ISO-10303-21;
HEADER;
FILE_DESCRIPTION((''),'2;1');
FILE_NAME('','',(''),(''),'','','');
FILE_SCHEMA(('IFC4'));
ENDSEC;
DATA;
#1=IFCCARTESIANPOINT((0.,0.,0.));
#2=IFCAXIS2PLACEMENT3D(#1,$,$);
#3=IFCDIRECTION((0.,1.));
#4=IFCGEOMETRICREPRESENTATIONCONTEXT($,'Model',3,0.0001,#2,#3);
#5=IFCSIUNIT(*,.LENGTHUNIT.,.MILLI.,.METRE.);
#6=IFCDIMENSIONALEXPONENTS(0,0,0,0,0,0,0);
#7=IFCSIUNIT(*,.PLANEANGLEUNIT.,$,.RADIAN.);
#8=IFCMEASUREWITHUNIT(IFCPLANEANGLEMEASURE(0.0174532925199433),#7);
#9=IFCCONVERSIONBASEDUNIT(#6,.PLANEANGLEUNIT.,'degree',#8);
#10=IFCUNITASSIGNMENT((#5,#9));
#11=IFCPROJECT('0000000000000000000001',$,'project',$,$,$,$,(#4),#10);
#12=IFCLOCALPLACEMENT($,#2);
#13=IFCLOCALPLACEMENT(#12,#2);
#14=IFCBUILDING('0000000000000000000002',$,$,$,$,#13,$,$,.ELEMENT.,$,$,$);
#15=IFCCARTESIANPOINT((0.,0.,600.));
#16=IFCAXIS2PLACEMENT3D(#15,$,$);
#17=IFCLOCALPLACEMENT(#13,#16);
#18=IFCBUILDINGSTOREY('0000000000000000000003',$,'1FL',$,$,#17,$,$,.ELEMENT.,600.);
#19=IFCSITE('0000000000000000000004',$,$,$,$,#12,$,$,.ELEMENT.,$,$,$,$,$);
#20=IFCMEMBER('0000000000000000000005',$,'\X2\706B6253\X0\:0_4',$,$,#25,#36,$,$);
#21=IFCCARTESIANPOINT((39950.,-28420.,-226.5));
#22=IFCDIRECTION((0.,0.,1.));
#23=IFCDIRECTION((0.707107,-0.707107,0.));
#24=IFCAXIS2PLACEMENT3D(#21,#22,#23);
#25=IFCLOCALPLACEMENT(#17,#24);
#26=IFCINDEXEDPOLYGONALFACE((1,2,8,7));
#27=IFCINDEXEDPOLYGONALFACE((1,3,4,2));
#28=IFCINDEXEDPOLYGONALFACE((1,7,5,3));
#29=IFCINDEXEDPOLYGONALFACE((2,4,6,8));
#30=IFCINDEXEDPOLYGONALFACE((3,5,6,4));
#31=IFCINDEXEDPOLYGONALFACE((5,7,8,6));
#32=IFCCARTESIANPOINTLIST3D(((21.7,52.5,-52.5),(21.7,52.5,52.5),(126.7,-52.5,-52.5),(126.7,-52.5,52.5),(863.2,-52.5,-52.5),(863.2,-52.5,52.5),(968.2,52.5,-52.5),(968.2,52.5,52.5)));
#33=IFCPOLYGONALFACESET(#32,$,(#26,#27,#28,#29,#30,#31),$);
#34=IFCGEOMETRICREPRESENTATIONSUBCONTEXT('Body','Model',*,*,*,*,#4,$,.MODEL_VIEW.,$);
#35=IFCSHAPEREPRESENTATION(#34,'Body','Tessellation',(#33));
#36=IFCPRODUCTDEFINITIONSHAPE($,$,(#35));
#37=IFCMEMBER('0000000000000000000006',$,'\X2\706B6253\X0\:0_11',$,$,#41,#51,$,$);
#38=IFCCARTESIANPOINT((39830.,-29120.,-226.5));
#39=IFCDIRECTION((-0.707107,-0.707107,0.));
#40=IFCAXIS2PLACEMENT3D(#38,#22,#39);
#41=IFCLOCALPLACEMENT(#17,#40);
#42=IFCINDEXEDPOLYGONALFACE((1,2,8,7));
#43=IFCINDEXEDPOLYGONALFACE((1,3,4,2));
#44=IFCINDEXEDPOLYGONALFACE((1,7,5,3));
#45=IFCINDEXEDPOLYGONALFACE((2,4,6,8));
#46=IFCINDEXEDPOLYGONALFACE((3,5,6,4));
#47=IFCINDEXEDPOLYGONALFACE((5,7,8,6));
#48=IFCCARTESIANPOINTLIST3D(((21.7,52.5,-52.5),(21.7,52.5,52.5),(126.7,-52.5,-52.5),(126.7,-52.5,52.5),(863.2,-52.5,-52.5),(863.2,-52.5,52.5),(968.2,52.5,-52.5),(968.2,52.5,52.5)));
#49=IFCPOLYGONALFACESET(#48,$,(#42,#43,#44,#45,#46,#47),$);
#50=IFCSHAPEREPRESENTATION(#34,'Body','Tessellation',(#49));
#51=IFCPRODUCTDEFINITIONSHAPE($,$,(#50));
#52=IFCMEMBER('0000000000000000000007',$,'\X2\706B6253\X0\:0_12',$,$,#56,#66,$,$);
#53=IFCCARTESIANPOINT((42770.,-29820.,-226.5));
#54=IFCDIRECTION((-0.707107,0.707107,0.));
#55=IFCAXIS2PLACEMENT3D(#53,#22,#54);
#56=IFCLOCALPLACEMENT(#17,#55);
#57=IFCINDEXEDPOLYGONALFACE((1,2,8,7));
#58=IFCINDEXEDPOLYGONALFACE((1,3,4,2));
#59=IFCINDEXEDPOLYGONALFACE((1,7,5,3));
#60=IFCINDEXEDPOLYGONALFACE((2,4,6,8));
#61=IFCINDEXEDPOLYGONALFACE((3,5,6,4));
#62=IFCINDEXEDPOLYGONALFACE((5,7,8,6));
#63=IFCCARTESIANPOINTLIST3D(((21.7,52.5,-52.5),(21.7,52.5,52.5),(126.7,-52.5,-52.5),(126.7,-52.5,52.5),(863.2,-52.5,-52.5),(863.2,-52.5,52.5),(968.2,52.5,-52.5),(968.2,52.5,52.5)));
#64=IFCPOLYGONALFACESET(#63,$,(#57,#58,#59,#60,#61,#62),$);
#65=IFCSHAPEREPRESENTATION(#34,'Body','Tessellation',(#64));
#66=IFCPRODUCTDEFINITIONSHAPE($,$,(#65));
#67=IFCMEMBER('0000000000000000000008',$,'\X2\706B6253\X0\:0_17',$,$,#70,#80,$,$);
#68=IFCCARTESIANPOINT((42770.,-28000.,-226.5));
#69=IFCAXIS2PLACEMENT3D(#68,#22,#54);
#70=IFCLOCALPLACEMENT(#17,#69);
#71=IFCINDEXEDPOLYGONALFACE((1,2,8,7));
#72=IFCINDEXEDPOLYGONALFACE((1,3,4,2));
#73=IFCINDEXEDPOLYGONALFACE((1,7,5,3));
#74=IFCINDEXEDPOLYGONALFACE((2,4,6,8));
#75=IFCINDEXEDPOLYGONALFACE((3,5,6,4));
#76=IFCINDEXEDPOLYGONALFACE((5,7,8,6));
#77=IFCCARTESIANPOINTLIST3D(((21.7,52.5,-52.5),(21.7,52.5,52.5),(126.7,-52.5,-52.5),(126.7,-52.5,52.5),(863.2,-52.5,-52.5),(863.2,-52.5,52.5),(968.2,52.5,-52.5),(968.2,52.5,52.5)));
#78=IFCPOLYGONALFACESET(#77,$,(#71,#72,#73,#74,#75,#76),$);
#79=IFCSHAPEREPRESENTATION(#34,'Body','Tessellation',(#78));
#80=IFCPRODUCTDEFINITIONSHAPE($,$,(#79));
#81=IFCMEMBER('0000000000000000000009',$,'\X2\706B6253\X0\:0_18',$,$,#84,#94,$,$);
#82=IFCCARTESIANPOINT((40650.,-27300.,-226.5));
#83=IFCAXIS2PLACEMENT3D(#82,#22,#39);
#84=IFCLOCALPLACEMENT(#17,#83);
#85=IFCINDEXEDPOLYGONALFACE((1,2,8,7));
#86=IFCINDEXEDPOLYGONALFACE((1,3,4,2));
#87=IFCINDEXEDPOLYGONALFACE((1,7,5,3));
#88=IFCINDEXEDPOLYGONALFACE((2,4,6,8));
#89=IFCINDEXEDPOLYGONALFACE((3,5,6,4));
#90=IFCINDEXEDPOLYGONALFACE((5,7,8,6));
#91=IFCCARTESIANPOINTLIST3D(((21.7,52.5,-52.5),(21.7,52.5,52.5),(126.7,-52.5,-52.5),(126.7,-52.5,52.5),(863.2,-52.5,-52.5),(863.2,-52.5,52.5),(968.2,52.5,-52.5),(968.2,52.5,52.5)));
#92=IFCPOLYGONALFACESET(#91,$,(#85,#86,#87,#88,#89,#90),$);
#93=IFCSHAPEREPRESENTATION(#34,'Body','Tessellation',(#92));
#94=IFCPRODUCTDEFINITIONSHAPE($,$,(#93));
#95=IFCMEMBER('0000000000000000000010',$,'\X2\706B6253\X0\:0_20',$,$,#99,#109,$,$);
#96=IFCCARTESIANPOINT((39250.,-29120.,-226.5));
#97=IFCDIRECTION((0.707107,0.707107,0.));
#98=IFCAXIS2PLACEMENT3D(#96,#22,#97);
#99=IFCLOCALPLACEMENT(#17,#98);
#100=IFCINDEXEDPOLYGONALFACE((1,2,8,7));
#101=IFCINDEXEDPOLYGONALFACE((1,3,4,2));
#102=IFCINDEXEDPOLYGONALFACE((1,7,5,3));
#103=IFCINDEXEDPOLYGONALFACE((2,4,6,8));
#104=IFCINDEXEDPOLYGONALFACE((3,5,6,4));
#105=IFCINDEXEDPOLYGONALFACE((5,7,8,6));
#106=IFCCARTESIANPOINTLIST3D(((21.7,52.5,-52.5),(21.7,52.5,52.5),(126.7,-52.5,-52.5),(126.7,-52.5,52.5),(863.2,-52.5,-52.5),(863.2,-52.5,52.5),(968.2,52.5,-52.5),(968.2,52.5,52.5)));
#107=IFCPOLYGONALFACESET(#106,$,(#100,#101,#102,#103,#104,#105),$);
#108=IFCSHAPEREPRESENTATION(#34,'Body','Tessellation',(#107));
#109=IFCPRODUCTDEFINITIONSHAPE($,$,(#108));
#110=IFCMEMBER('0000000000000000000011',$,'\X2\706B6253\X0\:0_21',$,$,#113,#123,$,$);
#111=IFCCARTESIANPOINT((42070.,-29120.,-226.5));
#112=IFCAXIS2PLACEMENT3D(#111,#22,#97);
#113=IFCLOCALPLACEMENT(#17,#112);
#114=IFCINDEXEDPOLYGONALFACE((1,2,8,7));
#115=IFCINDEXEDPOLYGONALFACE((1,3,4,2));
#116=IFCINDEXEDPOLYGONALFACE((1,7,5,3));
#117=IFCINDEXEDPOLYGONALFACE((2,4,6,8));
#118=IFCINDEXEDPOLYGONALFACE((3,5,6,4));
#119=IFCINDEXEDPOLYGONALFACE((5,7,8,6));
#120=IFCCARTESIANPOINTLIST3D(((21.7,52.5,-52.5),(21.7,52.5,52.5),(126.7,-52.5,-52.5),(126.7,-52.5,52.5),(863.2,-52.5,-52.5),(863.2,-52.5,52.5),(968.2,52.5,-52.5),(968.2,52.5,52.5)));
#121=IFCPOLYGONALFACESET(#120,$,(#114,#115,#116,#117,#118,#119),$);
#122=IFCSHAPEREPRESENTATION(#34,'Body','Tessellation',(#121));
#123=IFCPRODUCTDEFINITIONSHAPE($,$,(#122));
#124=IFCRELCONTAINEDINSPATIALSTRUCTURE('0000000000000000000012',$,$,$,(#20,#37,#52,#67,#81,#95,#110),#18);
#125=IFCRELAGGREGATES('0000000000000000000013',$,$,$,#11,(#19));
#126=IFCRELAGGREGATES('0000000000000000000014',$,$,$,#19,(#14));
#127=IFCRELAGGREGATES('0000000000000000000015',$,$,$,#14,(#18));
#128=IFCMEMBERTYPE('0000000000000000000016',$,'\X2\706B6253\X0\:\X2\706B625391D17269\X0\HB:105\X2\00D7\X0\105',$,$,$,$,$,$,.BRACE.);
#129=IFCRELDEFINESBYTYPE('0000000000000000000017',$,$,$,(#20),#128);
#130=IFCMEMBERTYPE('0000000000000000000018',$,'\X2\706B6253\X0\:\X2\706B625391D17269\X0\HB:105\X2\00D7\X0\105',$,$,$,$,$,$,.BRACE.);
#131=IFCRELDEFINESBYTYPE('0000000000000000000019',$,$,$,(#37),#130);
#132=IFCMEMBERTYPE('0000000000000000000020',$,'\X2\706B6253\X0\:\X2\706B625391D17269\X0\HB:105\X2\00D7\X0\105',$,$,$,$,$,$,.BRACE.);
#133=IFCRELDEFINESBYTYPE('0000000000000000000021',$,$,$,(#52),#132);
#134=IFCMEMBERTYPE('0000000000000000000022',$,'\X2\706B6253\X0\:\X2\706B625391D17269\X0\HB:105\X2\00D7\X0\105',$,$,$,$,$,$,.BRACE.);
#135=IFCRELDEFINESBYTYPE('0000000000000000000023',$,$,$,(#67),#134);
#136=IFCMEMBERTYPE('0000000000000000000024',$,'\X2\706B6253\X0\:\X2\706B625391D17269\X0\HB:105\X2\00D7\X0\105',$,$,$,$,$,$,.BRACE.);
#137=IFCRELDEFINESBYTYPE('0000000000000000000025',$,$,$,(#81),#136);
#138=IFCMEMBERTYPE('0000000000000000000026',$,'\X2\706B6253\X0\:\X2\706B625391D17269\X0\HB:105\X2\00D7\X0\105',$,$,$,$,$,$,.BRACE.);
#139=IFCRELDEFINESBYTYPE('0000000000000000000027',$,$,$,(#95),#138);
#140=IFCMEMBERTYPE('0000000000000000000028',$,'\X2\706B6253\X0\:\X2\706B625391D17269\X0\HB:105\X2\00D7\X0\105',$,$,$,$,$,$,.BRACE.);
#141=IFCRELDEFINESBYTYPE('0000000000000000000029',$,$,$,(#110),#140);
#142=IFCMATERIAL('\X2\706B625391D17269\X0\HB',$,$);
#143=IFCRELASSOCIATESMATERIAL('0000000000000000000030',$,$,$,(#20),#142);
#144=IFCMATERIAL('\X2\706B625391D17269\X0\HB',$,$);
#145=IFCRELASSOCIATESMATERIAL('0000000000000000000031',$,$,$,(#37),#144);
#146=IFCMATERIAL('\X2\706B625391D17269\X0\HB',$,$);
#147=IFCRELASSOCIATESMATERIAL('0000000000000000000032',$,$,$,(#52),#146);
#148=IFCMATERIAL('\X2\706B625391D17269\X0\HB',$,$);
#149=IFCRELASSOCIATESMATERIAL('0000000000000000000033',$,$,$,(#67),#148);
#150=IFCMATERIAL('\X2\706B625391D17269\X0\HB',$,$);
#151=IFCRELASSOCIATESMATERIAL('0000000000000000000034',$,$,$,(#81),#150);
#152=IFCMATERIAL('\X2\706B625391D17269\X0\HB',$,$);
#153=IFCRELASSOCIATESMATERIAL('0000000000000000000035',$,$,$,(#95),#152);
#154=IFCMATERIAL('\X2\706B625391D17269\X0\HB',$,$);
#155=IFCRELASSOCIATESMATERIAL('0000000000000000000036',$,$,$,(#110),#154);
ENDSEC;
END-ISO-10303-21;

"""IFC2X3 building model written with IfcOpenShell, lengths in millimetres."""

from ifc_helpers import new_model, entity, si_unit, converted_unit, direction, frame, origin, place, context, subcontext, project, spatial, polyline, outline, extrude, material, type_object, element, save


model = new_model("IFC2X3")

# Units and contexts
model_context = context("Model", 3, precision=0.0001, world=origin(), true_north=direction((0.0, 1.0)))
body_context = subcontext(model_context, "Body", "Model", "MODEL_VIEW")
ifc_project = project(units=[si_unit("LENGTHUNIT", "METRE", prefix="MILLI"), converted_unit("PLANEANGLEUNIT", "degree", entity("IfcPlaneAngleMeasure", 0.0174532925199433), si_unit("PLANEANGLEUNIT", "RADIAN"), dimensions=[0, 0, 0, 0, 0, 0, 0])], contexts=[model_context])

# Site, building, storey
site_placement = place(None, origin())
site = spatial("IfcSite", under=ifc_project, at=site_placement, CompositionType="ELEMENT")
building_placement = place(site_placement, origin())
building = spatial("IfcBuilding", under=site, at=building_placement, CompositionType="ELEMENT")
storey_placement = place(building_placement, frame((0.0, 0.0, 600.0)))
storey = spatial("IfcBuildingStorey", under=building, at=storey_placement, Name="1FL", CompositionType="ELEMENT", Elevation=600.0)

# Members
ifc_material_1 = material(Name="火打金物HB")
member_type_1 = type_object("IfcMemberType", Name="火打:火打金物HB:105×105", PredefinedType="BRACE")
member_1_placement = place(storey_placement, frame((39950.0, -28420.0, -226.5), z_axis=(0.0, 0.0, 1.0), x_axis=(0.707107, -0.707107, 0.0)))
element("IfcMember", 1, at=member_1_placement, inside=storey, type_object=member_type_1, material=ifc_material_1, Name="火打:0_4", context=body_context, shape_type="SweptSolid", body=[
    extrude(outline(polyline([(126.7, -52.5, 0.0), (21.7, 52.5, 0.0), (968.2, 52.5, 0.0), (863.2, -52.5, 0.0), (126.7, -52.5, 0.0)])), frame((0.0, 0.0, -52.5), z_axis=(0.0, 0.0, 1.0), x_axis=(1.0, 0.0, 0.0)), (0.0, 0.0, 1.0), 105.0),
])
ifc_material_2 = material(Name="火打金物HB")
member_type_2 = type_object("IfcMemberType", Name="火打:火打金物HB:105×105", PredefinedType="BRACE")
member_2_placement = place(storey_placement, frame((39830.0, -29120.0, -226.5), z_axis=(0.0, 0.0, 1.0), x_axis=(-0.707107, -0.707107, 0.0)))
element("IfcMember", 2, at=member_2_placement, inside=storey, type_object=member_type_2, material=ifc_material_2, Name="火打:0_11", context=body_context, shape_type="SweptSolid", body=[
    extrude(outline(polyline([(126.7, -52.5, 0.0), (21.7, 52.5, 0.0), (968.2, 52.5, 0.0), (863.2, -52.5, 0.0), (126.7, -52.5, 0.0)])), frame((0.0, 0.0, -52.5), z_axis=(0.0, 0.0, 1.0), x_axis=(1.0, 0.0, 0.0)), (0.0, 0.0, 1.0), 105.0),
])
ifc_material_3 = material(Name="火打金物HB")
member_type_3 = type_object("IfcMemberType", Name="火打:火打金物HB:105×105", PredefinedType="BRACE")
member_3_placement = place(storey_placement, frame((42770.0, -29820.0, -226.5), z_axis=(0.0, 0.0, 1.0), x_axis=(-0.707107, 0.707107, 0.0)))
element("IfcMember", 3, at=member_3_placement, inside=storey, type_object=member_type_3, material=ifc_material_3, Name="火打:0_12", context=body_context, shape_type="SweptSolid", body=[
    extrude(outline(polyline([(126.7, -52.5, 0.0), (21.7, 52.5, 0.0), (968.2, 52.5, 0.0), (863.2, -52.5, 0.0), (126.7, -52.5, 0.0)])), frame((0.0, 0.0, -52.5), z_axis=(0.0, 0.0, 1.0), x_axis=(1.0, 0.0, 0.0)), (0.0, 0.0, 1.0), 105.0),
])
ifc_material_4 = material(Name="火打金物HB")
member_type_4 = type_object("IfcMemberType", Name="火打:火打金物HB:105×105", PredefinedType="BRACE")
member_4_placement = place(storey_placement, frame((42770.0, -28000.0, -226.5), z_axis=(0.0, 0.0, 1.0), x_axis=(-0.707107, 0.707107, 0.0)))
element("IfcMember", 4, at=member_4_placement, inside=storey, type_object=member_type_4, material=ifc_material_4, Name="火打:0_17", context=body_context, shape_type="SweptSolid", body=[
    extrude(outline(polyline([(126.7, -52.5, 0.0), (21.7, 52.5, 0.0), (968.2, 52.5, 0.0), (863.2, -52.5, 0.0), (126.7, -52.5, 0.0)])), frame((0.0, 0.0, -52.5), z_axis=(0.0, 0.0, 1.0), x_axis=(1.0, 0.0, 0.0)), (0.0, 0.0, 1.0), 105.0),
])
ifc_material_5 = material(Name="火打金物HB")
member_type_5 = type_object("IfcMemberType", Name="火打:火打金物HB:105×105", PredefinedType="BRACE")
member_5_placement = place(storey_placement, frame((40650.0, -27300.0, -226.5), z_axis=(0.0, 0.0, 1.0), x_axis=(-0.707107, -0.707107, 0.0)))
element("IfcMember", 5, at=member_5_placement, inside=storey, type_object=member_type_5, material=ifc_material_5, Name="火打:0_18", context=body_context, shape_type="SweptSolid", body=[
    extrude(outline(polyline([(126.7, -52.5, 0.0), (21.7, 52.5, 0.0), (968.2, 52.5, 0.0), (863.2, -52.5, 0.0), (126.7, -52.5, 0.0)])), frame((0.0, 0.0, -52.5), z_axis=(0.0, 0.0, 1.0), x_axis=(1.0, 0.0, 0.0)), (0.0, 0.0, 1.0), 105.0),
])
ifc_material_6 = material(Name="火打金物HB")
member_type_6 = type_object("IfcMemberType", Name="火打:火打金物HB:105×105", PredefinedType="BRACE")
member_6_placement = place(storey_placement, frame((39250.0, -29120.0, -226.5), z_axis=(0.0, 0.0, 1.0), x_axis=(0.707107, 0.707107, 0.0)))
element("IfcMember", 6, at=member_6_placement, inside=storey, type_object=member_type_6, material=ifc_material_6, Name="火打:0_20", context=body_context, shape_type="SweptSolid", body=[
    extrude(outline(polyline([(126.7, -52.5, 0.0), (21.7, 52.5, 0.0), (968.2, 52.5, 0.0), (863.2, -52.5, 0.0), (126.7, -52.5, 0.0)])), frame((0.0, 0.0, -52.5), z_axis=(0.0, 0.0, 1.0), x_axis=(1.0, 0.0, 0.0)), (0.0, 0.0, 1.0), 105.0),
])
ifc_material_7 = material(Name="火打金物HB")
member_type_7 = type_object("IfcMemberType", Name="火打:火打金物HB:105×105", PredefinedType="BRACE")
member_7_placement = place(storey_placement, frame((42070.0, -29120.0, -226.5), z_axis=(0.0, 0.0, 1.0), x_axis=(0.707107, 0.707107, 0.0)))
element("IfcMember", 7, at=member_7_placement, inside=storey, type_object=member_type_7, material=ifc_material_7, Name="火打:0_21", context=body_context, shape_type="SweptSolid", body=[
    extrude(outline(polyline([(126.7, -52.5, 0.0), (21.7, 52.5, 0.0), (968.2, 52.5, 0.0), (863.2, -52.5, 0.0), (126.7, -52.5, 0.0)])), frame((0.0, 0.0, -52.5), z_axis=(0.0, 0.0, 1.0), x_axis=(1.0, 0.0, 0.0)), (0.0, 0.0, 1.0), 105.0),
])

save(model, "model.ifc")
